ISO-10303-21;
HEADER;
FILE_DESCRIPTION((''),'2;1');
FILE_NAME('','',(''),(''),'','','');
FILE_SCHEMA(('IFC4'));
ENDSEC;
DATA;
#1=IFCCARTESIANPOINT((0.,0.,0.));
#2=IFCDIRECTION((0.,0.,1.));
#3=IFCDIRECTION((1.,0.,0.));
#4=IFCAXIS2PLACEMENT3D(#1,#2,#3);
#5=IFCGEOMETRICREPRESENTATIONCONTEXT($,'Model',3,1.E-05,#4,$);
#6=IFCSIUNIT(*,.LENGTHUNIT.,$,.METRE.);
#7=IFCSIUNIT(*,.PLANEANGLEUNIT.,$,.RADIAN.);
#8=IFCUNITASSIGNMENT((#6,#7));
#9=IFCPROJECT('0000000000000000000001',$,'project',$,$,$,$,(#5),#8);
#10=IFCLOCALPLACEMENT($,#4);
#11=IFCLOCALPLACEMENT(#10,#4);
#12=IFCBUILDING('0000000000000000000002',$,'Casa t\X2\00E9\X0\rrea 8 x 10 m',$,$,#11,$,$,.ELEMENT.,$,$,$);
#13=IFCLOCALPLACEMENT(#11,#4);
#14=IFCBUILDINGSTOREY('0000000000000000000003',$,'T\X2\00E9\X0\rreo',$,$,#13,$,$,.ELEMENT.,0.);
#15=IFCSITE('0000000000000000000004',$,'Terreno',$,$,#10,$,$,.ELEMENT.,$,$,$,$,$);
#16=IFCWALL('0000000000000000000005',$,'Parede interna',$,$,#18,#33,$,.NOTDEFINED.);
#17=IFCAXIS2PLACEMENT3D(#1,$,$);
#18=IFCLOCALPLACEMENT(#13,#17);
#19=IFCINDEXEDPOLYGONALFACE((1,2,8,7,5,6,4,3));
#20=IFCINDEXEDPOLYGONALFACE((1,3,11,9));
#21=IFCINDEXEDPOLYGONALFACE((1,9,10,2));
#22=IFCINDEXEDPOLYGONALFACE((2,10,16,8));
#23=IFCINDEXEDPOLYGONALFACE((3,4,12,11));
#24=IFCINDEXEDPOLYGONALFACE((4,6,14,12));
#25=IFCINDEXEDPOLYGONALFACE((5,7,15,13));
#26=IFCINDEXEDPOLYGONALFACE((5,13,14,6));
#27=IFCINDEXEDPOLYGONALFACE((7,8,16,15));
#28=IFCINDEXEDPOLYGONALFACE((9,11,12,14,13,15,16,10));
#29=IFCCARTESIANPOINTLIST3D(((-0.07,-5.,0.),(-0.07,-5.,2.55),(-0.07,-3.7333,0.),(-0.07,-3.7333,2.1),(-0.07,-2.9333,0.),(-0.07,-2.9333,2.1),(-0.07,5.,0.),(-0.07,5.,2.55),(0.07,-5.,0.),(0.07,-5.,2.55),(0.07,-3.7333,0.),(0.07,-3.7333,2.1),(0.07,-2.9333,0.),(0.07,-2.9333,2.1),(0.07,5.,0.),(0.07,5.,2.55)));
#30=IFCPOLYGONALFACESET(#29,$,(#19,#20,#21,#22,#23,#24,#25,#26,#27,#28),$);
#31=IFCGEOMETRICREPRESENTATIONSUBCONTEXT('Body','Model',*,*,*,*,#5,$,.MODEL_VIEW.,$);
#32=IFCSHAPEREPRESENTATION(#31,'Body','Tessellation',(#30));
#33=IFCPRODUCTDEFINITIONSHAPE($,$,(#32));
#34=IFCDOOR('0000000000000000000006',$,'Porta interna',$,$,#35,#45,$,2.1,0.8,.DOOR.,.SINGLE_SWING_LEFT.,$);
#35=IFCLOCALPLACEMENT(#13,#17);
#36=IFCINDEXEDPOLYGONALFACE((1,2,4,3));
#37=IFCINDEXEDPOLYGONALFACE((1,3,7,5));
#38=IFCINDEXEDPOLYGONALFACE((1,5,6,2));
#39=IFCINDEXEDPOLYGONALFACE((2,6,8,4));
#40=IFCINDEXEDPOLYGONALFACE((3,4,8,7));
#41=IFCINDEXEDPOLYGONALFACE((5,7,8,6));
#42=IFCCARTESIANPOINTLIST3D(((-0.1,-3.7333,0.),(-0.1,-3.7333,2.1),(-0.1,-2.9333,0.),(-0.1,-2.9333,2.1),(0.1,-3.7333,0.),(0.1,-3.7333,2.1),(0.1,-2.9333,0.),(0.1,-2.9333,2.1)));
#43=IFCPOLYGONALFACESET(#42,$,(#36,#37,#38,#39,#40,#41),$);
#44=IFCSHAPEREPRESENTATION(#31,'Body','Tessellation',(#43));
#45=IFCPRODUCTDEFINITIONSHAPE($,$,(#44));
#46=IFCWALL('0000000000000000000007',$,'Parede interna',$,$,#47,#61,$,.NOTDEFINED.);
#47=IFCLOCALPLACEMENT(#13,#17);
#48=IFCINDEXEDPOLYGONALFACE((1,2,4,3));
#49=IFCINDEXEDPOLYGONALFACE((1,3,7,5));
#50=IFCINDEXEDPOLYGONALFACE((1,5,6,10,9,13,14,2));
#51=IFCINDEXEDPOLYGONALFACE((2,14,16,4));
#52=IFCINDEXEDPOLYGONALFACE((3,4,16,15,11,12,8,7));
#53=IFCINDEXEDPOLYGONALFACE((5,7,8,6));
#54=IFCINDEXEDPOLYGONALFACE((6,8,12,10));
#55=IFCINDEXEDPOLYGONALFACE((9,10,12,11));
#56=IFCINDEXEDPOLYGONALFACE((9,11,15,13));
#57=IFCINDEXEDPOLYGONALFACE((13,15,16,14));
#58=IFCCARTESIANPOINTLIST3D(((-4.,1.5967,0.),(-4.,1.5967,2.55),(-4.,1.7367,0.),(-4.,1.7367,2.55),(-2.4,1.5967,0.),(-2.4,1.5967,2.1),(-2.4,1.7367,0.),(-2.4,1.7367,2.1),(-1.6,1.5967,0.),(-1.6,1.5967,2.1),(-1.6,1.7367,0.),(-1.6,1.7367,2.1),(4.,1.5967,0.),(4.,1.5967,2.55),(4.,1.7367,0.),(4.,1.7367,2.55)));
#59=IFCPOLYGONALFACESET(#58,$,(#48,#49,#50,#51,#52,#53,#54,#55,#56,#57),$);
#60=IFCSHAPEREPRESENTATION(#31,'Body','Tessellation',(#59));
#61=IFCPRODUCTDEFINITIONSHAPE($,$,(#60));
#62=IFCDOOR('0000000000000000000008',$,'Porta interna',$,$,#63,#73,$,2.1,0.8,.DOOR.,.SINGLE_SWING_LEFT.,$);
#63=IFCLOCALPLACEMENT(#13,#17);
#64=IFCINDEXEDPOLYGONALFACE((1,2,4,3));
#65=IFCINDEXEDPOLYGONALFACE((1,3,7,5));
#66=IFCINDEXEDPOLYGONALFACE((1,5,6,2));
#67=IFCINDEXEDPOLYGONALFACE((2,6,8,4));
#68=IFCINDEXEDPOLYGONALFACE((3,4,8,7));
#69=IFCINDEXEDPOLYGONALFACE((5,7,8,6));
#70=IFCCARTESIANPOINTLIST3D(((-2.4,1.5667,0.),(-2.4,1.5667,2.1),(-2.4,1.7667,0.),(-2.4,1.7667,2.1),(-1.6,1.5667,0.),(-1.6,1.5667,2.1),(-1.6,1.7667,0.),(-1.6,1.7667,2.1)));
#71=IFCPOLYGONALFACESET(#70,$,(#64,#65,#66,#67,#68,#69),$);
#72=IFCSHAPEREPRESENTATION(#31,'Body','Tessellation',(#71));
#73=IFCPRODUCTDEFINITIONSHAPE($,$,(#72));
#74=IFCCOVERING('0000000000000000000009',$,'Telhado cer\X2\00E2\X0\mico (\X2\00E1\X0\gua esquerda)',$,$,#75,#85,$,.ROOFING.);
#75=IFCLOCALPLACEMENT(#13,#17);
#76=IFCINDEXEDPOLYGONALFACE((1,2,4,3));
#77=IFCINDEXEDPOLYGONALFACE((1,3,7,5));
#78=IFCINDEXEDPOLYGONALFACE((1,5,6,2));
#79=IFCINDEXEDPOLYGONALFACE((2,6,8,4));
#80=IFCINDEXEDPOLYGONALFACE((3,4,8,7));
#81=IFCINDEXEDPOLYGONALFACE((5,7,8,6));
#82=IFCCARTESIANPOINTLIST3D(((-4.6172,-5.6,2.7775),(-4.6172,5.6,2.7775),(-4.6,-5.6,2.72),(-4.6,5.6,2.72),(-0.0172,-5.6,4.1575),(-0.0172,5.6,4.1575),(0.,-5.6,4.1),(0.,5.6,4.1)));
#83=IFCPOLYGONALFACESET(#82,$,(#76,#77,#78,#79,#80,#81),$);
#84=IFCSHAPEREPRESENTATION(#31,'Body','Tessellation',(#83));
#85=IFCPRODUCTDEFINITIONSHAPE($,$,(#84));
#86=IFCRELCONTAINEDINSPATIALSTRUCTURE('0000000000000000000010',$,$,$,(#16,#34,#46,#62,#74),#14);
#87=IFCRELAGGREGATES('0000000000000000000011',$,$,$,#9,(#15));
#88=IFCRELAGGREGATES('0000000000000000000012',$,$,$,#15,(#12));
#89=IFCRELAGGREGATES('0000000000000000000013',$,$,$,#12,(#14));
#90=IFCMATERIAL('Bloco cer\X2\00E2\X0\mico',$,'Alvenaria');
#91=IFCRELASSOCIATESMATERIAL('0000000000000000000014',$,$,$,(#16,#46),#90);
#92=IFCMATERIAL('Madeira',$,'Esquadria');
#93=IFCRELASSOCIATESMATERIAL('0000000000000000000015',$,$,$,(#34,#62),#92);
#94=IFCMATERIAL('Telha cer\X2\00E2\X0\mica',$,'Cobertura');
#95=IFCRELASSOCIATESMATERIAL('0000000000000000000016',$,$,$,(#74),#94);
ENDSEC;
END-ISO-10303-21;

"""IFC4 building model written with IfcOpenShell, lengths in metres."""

from ifc_helpers import new_model, si_unit, frame, origin_with_axes, origin_2d, place, context, subcontext, project, spatial, rectangle, extrude, material, element, fill, save


model = new_model("IFC4")

# Units and contexts
model_context = context("Model", 3, precision=1e-05, world=origin_with_axes())
body_context = subcontext(model_context, "Body", "Model", "MODEL_VIEW")
ifc_project = project(units=[si_unit("LENGTHUNIT", "METRE"), si_unit("PLANEANGLEUNIT", "RADIAN")], contexts=[model_context])

# Site, building, storey
site_placement = place(None, origin_with_axes())
site = spatial("IfcSite", under=ifc_project, at=site_placement, Name="Terreno", CompositionType="ELEMENT")
building_placement = place(site_placement, origin_with_axes())
building = spatial("IfcBuilding", under=site, at=building_placement, Name="Casa térrea 8 x 10 m", CompositionType="ELEMENT")
storey_placement = place(building_placement, origin_with_axes())
storey = spatial("IfcBuildingStorey", under=building, at=storey_placement, Name="Térreo", CompositionType="ELEMENT", Elevation=0.0)

# Shared definitions
ifc_material_1 = material(Name="Bloco cerâmico", Category="Alvenaria")

# Walls, openings, doors
wall_1_placement = place(storey_placement, origin_with_axes())
wall_1 = element("IfcWall", 1, at=wall_1_placement, inside=storey, material=ifc_material_1, Name="Parede interna", PredefinedType="NOTDEFINED", context=body_context, shape_type="SweptSolid", body=[
    extrude(rectangle(XDim=0.14, YDim=10.0, at=origin_2d()), None, (0.0, 0.0, 1.0), 2.55),
])
opening_1_placement = place(storey_placement, frame((0.0, -3.3333, 0.0), z_axis=(0.0, 0.0, 1.0), x_axis=(1.0, 0.0, 0.0)))
opening_1 = element("IfcOpeningElement", 2, at=opening_1_placement, cuts=wall_1, PredefinedType="OPENING", context=body_context, shape_type="SweptSolid", body=[
    extrude(rectangle(XDim=0.4, YDim=0.8, at=origin_2d()), None, (0.0, 0.0, 1.0), 2.1),
])
ifc_material_2 = material(Name="Madeira", Category="Esquadria")
door_1_placement = place(storey_placement, frame((0.0, -3.3333, 0.0), z_axis=(0.0, 0.0, 1.0), x_axis=(1.0, 0.0, 0.0)))
door_1 = element("IfcDoor", 3, at=door_1_placement, inside=storey, material=ifc_material_2, Name="Porta interna", OperationType="SINGLE_SWING_LEFT", OverallHeight=2.1, OverallWidth=0.8, PredefinedType="DOOR", context=body_context, shape_type="SweptSolid", body=[
    extrude(rectangle(XDim=0.2, YDim=0.8, at=origin_2d()), None, (0.0, 0.0, 1.0), 2.1),
])
fill(opening_1, door_1)
wall_2_placement = place(storey_placement, frame((0.0, 1.6667, 0.0), z_axis=(0.0, 0.0, 1.0), x_axis=(1.0, 0.0, 0.0)))
wall_2 = element("IfcWall", 4, at=wall_2_placement, inside=storey, material=ifc_material_1, Name="Parede interna", PredefinedType="NOTDEFINED", context=body_context, shape_type="SweptSolid", body=[
    extrude(rectangle(XDim=8.0, YDim=0.14, at=origin_2d()), None, (0.0, 0.0, 1.0), 2.55),
])
opening_2_placement = place(storey_placement, frame((-2.0, 1.6667, 0.0), z_axis=(0.0, 0.0, 1.0), x_axis=(1.0, 0.0, 0.0)))
opening_2 = element("IfcOpeningElement", 5, at=opening_2_placement, cuts=wall_2, PredefinedType="OPENING", context=body_context, shape_type="SweptSolid", body=[
    extrude(rectangle(XDim=0.8, YDim=0.4, at=origin_2d()), None, (0.0, 0.0, 1.0), 2.1),
])
door_2_placement = place(storey_placement, frame((-2.0, 1.6667, 0.0), z_axis=(0.0, 0.0, 1.0), x_axis=(1.0, 0.0, 0.0)))
door_2 = element("IfcDoor", 6, at=door_2_placement, inside=storey, material=ifc_material_2, Name="Porta interna", OperationType="SINGLE_SWING_LEFT", OverallHeight=2.1, OverallWidth=0.8, PredefinedType="DOOR", context=body_context, shape_type="SweptSolid", body=[
    extrude(rectangle(XDim=0.8, YDim=0.2, at=origin_2d()), None, (0.0, 0.0, 1.0), 2.1),
])
fill(opening_2, door_2)

# Covering
ifc_material_3 = material(Name="Telha cerâmica", Category="Cobertura")
covering_placement = place(storey_placement, frame((-2.3, 0.0, 3.41), z_axis=(-0.287348, 0.0, 0.957826), x_axis=(0.957826, 0.0, 0.287348)))
element("IfcCovering", 7, at=covering_placement, inside=storey, material=ifc_material_3, Name="Telhado cerâmico (água esquerda)", PredefinedType="ROOFING", context=body_context, shape_type="SweptSolid", body=[
    extrude(rectangle(XDim=4.8025, YDim=11.2, at=origin_2d()), None, (0.0, 0.0, 1.0), 0.06),
])

save(model, "model.ifc")
